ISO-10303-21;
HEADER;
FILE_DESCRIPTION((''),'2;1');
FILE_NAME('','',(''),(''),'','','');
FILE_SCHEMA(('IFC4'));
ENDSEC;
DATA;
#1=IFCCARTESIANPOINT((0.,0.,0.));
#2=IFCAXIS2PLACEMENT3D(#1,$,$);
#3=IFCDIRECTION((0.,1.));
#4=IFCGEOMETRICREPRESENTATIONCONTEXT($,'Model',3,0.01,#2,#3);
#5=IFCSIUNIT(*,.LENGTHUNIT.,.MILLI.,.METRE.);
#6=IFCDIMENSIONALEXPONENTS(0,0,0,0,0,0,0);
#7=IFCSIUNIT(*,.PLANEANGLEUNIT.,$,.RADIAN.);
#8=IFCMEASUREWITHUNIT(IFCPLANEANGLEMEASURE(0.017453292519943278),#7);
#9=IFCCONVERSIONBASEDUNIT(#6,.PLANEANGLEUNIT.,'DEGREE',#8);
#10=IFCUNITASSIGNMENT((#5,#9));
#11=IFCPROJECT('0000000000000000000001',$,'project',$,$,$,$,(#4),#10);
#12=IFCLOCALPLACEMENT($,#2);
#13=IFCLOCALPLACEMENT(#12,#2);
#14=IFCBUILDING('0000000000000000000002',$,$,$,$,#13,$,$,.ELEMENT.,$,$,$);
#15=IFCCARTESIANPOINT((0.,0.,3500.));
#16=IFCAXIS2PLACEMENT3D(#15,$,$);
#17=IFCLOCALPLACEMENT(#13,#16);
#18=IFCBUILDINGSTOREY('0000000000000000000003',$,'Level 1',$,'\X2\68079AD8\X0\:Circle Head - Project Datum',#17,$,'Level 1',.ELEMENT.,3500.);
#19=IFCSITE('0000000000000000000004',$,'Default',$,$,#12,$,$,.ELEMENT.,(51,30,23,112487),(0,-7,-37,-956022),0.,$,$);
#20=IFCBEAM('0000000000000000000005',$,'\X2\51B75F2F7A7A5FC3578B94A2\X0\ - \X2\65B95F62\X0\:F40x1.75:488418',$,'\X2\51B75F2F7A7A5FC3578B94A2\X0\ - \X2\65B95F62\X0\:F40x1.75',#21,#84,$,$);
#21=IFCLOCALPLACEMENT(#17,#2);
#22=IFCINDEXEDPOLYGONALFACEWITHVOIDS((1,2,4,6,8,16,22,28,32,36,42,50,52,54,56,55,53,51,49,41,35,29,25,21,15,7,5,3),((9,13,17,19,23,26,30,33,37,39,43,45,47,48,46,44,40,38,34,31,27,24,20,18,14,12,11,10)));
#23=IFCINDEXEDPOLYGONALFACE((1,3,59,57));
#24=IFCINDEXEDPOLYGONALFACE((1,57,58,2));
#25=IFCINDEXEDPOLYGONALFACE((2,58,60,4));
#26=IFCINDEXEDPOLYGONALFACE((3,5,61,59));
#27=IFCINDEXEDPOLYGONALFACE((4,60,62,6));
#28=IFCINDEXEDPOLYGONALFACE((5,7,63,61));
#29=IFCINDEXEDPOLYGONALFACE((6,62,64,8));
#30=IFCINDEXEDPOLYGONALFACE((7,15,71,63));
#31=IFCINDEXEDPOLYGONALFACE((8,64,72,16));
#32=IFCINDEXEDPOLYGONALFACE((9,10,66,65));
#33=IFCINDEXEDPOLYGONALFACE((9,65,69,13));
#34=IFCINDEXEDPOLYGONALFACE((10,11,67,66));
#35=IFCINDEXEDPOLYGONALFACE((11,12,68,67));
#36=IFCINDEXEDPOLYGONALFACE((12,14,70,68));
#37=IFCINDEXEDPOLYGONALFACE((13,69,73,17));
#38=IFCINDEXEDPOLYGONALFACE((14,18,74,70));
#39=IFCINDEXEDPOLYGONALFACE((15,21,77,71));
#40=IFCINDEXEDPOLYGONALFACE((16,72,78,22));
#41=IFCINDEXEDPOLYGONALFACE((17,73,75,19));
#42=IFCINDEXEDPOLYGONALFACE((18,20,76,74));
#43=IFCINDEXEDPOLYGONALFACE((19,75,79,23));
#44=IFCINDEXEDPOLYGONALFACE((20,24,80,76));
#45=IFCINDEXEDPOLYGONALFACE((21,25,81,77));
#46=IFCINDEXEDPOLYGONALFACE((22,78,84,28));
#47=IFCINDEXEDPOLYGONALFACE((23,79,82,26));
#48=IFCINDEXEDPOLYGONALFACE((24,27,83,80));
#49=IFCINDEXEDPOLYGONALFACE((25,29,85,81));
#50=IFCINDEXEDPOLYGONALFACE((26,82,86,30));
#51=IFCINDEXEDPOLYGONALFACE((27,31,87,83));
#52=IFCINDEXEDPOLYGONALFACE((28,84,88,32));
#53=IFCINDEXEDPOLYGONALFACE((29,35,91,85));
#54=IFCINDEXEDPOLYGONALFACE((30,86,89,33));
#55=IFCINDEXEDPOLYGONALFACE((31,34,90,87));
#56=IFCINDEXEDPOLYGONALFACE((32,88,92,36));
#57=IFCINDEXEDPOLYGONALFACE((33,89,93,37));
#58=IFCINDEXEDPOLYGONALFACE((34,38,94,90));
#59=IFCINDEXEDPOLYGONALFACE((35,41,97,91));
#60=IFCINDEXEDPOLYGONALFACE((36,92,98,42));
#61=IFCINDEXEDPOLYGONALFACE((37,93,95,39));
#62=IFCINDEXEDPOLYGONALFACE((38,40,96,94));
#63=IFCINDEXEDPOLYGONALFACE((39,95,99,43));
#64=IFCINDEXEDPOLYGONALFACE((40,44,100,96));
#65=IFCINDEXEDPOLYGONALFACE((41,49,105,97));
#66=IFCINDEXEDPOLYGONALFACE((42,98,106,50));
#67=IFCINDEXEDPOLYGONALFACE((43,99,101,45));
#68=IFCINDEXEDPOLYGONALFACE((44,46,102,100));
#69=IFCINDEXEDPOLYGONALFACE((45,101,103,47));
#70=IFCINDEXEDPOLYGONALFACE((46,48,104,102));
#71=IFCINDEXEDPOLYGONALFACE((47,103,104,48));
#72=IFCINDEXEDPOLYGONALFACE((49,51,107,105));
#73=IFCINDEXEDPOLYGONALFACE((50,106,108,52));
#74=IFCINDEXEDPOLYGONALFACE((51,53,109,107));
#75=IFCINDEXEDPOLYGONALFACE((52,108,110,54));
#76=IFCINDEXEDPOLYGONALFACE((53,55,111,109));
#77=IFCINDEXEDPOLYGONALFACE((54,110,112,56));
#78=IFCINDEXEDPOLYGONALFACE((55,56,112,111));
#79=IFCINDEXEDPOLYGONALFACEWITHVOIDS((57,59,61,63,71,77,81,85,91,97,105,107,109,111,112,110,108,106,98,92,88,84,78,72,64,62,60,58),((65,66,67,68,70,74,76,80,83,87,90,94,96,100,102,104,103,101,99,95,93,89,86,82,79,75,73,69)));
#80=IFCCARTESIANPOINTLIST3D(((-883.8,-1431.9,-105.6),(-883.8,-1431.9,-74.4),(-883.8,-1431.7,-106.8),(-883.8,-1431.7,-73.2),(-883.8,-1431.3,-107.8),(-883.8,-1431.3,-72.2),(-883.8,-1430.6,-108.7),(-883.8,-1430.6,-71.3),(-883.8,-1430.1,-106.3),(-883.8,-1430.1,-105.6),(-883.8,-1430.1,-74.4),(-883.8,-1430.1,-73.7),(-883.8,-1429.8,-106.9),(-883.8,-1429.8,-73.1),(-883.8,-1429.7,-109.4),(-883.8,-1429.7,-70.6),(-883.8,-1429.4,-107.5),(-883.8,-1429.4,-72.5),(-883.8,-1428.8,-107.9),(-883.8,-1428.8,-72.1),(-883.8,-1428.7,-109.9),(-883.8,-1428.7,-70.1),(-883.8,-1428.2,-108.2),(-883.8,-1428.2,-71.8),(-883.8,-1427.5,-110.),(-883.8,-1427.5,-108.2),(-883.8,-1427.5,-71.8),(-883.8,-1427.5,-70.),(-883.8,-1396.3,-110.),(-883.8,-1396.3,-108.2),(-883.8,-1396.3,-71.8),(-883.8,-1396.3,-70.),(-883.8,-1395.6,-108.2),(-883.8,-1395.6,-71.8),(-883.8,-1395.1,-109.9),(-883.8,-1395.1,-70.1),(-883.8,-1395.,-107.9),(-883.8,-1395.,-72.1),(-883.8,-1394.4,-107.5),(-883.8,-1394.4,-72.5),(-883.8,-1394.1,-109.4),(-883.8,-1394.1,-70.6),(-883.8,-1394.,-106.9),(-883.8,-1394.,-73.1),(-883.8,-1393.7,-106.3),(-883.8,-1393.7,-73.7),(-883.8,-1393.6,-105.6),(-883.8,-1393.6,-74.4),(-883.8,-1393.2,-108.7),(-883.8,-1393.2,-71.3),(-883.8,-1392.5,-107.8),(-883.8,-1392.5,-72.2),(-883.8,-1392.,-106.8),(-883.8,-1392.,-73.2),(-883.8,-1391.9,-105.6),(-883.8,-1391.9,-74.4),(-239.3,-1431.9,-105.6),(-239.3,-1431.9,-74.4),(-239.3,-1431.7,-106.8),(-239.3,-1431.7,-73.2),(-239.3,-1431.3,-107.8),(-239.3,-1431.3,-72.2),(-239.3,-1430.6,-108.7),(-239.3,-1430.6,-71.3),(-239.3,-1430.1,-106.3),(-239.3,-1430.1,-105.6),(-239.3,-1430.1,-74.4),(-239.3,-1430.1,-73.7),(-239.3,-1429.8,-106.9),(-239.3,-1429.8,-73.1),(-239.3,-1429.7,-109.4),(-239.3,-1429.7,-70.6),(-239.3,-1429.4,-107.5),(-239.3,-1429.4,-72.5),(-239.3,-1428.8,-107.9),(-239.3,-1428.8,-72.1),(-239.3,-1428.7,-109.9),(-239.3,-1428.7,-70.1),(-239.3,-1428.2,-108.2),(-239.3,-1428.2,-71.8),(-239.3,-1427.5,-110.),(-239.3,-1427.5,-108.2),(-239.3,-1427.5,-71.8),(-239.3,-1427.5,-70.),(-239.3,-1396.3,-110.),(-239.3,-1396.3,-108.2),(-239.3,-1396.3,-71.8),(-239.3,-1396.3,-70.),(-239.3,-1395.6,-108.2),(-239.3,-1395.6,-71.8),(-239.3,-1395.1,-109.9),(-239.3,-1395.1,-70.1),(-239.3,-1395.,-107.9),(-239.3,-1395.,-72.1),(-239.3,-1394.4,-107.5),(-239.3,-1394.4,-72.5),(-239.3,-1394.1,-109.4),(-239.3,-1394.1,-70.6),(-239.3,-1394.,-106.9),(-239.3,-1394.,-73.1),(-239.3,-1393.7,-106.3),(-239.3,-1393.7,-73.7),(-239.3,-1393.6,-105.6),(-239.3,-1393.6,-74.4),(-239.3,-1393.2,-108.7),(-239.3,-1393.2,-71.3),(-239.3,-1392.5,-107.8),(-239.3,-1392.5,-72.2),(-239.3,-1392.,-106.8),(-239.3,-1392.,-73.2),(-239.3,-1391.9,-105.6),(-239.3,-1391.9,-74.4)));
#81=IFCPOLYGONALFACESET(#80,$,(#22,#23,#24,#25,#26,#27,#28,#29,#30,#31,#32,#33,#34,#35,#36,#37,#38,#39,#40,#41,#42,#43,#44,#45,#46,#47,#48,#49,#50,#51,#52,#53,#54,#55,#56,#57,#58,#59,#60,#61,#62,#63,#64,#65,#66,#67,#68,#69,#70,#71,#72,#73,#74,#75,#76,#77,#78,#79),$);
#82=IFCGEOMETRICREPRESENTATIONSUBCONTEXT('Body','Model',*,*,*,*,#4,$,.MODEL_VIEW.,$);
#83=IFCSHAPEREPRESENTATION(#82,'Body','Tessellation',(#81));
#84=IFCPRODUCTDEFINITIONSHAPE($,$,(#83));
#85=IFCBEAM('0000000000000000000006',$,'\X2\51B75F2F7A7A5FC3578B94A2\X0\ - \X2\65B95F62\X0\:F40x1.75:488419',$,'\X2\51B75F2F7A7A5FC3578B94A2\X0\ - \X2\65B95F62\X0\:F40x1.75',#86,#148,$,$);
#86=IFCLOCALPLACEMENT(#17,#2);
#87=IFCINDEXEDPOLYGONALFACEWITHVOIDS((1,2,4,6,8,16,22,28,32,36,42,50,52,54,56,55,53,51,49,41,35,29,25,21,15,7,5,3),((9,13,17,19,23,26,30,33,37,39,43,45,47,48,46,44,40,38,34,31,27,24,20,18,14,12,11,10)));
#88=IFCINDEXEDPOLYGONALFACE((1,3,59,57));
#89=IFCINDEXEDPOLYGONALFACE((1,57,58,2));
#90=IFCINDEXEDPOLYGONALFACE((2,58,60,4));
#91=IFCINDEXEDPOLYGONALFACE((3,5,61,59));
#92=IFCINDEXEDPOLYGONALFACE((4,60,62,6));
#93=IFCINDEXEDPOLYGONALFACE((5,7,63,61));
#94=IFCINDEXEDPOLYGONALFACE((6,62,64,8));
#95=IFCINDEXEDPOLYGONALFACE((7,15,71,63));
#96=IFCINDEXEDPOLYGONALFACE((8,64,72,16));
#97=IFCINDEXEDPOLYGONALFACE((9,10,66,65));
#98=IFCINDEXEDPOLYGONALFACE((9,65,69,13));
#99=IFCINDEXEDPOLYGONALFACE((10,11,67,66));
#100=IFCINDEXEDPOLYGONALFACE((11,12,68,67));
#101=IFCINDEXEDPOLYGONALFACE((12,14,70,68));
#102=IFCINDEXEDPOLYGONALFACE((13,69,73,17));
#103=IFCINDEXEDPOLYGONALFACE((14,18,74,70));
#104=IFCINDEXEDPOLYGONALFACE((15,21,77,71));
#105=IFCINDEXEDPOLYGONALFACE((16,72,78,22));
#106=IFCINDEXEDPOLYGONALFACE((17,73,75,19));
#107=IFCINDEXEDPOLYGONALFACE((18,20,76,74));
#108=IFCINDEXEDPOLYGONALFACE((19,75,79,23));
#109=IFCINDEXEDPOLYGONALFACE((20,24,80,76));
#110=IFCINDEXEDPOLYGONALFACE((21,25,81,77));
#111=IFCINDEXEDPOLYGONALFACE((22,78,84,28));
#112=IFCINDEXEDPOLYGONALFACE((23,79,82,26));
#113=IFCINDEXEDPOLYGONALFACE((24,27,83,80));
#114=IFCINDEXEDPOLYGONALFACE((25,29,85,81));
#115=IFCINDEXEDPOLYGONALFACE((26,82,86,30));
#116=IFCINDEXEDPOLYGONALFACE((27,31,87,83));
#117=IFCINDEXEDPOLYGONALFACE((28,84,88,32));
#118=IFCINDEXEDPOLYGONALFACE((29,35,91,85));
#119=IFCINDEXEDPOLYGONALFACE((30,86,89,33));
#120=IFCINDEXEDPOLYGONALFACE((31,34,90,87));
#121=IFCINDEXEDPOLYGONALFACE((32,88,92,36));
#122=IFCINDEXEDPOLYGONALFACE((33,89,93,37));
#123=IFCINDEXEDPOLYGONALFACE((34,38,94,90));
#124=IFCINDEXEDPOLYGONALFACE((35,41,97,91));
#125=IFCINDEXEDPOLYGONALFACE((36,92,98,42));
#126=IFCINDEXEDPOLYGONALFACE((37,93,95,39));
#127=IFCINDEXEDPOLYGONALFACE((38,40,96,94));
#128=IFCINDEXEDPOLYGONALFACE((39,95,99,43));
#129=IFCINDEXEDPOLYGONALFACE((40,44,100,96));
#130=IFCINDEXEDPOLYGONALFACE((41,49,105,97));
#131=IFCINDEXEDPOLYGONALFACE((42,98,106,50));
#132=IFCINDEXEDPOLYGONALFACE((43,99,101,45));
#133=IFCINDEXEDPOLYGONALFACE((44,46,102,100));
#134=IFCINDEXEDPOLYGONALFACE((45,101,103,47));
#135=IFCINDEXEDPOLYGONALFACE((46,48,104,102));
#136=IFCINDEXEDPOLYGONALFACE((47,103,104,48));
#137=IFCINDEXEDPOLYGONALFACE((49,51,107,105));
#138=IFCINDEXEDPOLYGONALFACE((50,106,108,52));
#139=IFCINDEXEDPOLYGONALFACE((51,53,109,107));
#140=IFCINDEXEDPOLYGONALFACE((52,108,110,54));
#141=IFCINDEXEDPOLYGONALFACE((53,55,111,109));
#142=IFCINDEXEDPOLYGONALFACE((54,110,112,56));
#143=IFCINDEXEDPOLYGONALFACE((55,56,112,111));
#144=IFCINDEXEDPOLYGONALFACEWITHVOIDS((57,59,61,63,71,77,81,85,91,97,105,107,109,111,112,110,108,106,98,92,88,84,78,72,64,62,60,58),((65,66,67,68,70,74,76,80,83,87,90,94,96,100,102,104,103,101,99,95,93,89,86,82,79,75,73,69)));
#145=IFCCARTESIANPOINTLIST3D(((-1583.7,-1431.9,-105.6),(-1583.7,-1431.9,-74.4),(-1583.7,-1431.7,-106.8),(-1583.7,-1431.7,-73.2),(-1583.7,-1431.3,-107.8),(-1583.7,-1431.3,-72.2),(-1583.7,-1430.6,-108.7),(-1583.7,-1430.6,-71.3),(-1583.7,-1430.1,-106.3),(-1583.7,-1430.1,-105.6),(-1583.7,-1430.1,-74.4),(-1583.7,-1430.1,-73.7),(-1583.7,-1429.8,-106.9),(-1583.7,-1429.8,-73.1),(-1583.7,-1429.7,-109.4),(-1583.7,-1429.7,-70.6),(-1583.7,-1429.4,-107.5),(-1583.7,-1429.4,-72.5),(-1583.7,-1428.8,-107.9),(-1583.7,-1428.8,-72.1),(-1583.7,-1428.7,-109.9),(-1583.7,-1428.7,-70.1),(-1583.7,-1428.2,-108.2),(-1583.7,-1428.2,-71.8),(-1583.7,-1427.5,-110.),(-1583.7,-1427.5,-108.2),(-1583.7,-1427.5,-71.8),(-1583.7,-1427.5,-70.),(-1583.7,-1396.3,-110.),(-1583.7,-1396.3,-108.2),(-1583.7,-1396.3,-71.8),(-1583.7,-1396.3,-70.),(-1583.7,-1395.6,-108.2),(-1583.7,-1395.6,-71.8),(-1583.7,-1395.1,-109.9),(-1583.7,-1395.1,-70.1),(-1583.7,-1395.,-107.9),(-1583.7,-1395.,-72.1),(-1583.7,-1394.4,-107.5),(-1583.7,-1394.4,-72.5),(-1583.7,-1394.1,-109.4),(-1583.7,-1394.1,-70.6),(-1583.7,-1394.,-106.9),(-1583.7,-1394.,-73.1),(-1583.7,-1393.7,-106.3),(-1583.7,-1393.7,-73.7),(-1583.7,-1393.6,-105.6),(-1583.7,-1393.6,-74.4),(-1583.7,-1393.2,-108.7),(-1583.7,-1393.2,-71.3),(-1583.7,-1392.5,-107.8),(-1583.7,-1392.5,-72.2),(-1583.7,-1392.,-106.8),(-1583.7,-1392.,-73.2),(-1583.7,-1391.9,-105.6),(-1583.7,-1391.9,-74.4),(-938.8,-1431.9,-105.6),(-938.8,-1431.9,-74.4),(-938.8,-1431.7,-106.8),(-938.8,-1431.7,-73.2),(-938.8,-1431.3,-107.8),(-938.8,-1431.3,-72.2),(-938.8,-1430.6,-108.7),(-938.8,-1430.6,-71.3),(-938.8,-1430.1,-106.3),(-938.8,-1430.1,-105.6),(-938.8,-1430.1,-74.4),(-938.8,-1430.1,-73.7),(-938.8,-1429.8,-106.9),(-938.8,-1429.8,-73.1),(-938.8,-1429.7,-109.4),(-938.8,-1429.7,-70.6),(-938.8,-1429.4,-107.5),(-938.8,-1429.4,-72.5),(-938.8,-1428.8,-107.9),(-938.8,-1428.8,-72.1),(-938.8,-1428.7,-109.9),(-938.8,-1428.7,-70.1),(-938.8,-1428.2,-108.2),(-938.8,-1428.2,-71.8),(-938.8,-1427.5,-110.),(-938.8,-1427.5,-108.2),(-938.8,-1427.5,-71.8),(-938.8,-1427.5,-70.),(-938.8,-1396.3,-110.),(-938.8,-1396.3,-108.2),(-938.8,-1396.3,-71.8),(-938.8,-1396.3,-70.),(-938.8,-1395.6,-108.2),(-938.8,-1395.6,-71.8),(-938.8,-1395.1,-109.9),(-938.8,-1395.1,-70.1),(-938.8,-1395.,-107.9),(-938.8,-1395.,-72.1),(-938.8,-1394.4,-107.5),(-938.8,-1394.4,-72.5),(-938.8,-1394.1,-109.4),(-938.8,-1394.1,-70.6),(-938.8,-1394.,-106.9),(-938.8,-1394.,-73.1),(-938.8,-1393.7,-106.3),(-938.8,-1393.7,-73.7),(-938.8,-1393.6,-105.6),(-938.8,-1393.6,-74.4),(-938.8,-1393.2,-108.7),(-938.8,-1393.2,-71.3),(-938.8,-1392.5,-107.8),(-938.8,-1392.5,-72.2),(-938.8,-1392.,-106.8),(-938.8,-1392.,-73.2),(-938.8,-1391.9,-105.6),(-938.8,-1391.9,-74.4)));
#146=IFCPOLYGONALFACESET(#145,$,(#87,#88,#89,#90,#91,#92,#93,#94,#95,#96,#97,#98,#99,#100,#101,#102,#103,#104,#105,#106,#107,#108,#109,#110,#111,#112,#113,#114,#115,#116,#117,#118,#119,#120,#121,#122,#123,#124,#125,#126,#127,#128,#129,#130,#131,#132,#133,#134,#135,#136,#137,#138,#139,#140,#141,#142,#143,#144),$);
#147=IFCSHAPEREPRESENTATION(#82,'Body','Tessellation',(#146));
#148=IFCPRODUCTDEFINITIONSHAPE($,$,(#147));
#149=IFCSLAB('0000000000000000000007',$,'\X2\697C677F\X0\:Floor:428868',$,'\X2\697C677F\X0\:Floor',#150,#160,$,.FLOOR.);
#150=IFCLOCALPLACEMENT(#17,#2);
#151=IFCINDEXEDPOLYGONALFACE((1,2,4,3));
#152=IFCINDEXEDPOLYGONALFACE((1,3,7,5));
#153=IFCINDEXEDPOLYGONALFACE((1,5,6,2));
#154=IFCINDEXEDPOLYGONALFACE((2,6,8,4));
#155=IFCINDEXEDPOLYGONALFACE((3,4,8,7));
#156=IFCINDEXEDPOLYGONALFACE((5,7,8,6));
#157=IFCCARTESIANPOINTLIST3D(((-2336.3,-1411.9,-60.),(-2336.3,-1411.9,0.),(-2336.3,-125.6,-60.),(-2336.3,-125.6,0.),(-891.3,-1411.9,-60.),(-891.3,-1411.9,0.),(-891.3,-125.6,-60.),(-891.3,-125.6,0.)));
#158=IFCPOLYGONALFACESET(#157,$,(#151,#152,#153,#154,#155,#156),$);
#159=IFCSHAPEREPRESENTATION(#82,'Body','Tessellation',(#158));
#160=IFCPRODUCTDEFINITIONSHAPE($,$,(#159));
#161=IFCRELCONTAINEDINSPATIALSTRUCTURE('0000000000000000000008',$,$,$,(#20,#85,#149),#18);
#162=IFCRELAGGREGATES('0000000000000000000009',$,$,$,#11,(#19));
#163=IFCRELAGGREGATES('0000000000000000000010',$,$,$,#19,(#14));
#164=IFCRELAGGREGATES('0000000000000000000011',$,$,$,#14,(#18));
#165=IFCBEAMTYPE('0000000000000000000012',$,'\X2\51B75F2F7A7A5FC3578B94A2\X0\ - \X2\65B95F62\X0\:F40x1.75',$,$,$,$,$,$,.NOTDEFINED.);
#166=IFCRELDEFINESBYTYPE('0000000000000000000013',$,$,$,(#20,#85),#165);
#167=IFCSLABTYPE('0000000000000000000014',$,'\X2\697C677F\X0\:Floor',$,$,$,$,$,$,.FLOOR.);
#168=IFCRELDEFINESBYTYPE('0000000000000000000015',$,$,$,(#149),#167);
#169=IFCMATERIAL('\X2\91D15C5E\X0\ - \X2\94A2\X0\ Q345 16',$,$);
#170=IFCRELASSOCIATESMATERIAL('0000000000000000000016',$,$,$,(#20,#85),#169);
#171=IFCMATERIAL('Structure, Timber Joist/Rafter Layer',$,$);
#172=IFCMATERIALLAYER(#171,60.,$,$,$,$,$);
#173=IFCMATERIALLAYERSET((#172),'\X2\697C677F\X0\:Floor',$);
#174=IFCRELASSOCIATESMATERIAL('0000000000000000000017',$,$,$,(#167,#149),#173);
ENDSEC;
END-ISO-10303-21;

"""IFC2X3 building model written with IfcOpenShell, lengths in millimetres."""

from ifc_helpers import new_model, entity, si_unit, converted_unit, direction, frame, frame_2d, origin, place, context, subcontext, project, spatial, polyline, circle_curve, parameter, trimmed, segment, composite_curve, rectangle, outline, extrude, material, layer, layer_set, layer_usage, type_object, element, save


model = new_model("IFC2X3")

# Units and contexts
model_context = context("Model", 3, precision=0.01, world=origin(), true_north=direction((0.0, 1.0)))
body_context = subcontext(model_context, "Body", "Model", "MODEL_VIEW")
ifc_project = project(units=[si_unit("LENGTHUNIT", "METRE", prefix="MILLI"), converted_unit("PLANEANGLEUNIT", "DEGREE", entity("IfcPlaneAngleMeasure", 0.017453292519943278), si_unit("PLANEANGLEUNIT", "RADIAN"), dimensions=[0, 0, 0, 0, 0, 0, 0])], contexts=[model_context])

# Site, building, storey
site_placement = place(None, origin())
site = spatial("IfcSite", under=ifc_project, at=site_placement, Name="Default", CompositionType="ELEMENT", RefLatitude=(51, 30, 23, 112487), RefLongitude=(0, -7, -37, -956022), RefElevation=0.0)
building_placement = place(site_placement, origin())
building = spatial("IfcBuilding", under=site, at=building_placement, CompositionType="ELEMENT")
storey_placement = place(building_placement, frame((0.0, 0.0, 3500.0)))
storey = spatial("IfcBuildingStorey", under=building, at=storey_placement, Name="Level 1", ObjectType="标高:Circle Head - Project Datum", LongName="Level 1", CompositionType="ELEMENT", Elevation=3500.0)

# Beams
ifc_material_1 = material(Name="金属 - 钢 Q345 16")
beam_type_1 = type_object("IfcBeamType", Name="冷弯空心型钢 - 方形:F40x1.75", PredefinedType="NOTDEFINED")
beam_1_placement = place(storey_placement, frame((-911.3, -1411.9, -70.0)))
element("IfcBeam", 1, at=beam_1_placement, inside=storey, type_object=beam_type_1, material=ifc_material_1, Name="冷弯空心型钢 - 方形:F40x1.75:488418", ObjectType="冷弯空心型钢 - 方形:F40x1.75", context=body_context, shape_type="SweptSolid", body=[
    extrude(outline(composite_curve([segment(trimmed(circle_curve(frame_2d((-15.6, 15.6), x_axis=(1.0, 0.0)), 4.4), [parameter(90.0)], [parameter(180.0)], True, "PARAMETER"), True, "CONTINUOUS"), segment(polyline([(-20.0, 15.6), (-20.0, -15.6)]), True, "CONTINUOUS"), segment(trimmed(circle_curve(frame_2d((-15.6, -15.6), x_axis=(1.0, 0.0)), 4.4), [parameter(180.0)], [parameter(270.0)], True, "PARAMETER"), True, "CONTINUOUS"), segment(polyline([(-15.6, -20.0), (15.6, -20.0)]), True, "CONTINUOUS"), segment(trimmed(circle_curve(frame_2d((15.6, -15.6), x_axis=(1.0, 0.0)), 4.4), [parameter(270.0)], [parameter(0.0)], True, "PARAMETER"), True, "CONTINUOUS"), segment(polyline([(20.0, -15.6), (20.0, 15.6)]), True, "CONTINUOUS"), segment(trimmed(circle_curve(frame_2d((15.6, 15.6), x_axis=(1.0, 0.0)), 4.4), [parameter(0.0)], [parameter(90.0)], True, "PARAMETER"), True, "CONTINUOUS"), segment(polyline([(15.6, 20.0), (-15.6, 20.0)]), True, "CONTINUOUS")], self_intersect=False), holes=[composite_curve([segment(polyline([(-15.6, 18.3), (15.6, 18.3)]), True, "CONTINUOUS"), segment(trimmed(circle_curve(frame_2d((15.6, 15.6), x_axis=(1.0, 0.0)), 2.6), [parameter(0.0)], [parameter(90.0)], True, "PARAMETER"), False, "CONTINUOUS"), segment(polyline([(18.2, 15.6), (18.2, -15.6)]), True, "CONTINUOUS"), segment(trimmed(circle_curve(frame_2d((15.6, -15.6), x_axis=(1.0, 0.0)), 2.6), [parameter(270.0)], [parameter(360.0)], True, "PARAMETER"), False, "CONTINUOUS"), segment(polyline([(15.6, -18.3), (-15.6, -18.3)]), True, "CONTINUOUS"), segment(trimmed(circle_curve(frame_2d((-15.6, -15.6), x_axis=(1.0, 0.0)), 2.6), [parameter(180.0)], [parameter(270.0)], True, "PARAMETER"), False, "CONTINUOUS"), segment(polyline([(-18.3, -15.6), (-18.3, 15.6)]), True, "CONTINUOUS"), segment(trimmed(circle_curve(frame_2d((-15.6, 15.6), x_axis=(1.0, 0.0)), 2.6), [parameter(90.0)], [parameter(180.0)], True, "PARAMETER"), False, "CONTINUOUS")], self_intersect=False)]), frame((27.5, 0.0, -20.0), z_axis=(1.0, 0.0, 0.0), x_axis=(0.0, 1.0, 0.0)), (0.0, 0.0, 1.0), 644.5),
])
beam_2_placement = place(storey_placement, frame((-1651.3, -1411.9, -70.0)))
element("IfcBeam", 2, at=beam_2_placement, inside=storey, type_object=beam_type_1, material=ifc_material_1, Name="冷弯空心型钢 - 方形:F40x1.75:488419", ObjectType="冷弯空心型钢 - 方形:F40x1.75", context=body_context, shape_type="SweptSolid", body=[
    extrude(outline(composite_curve([segment(trimmed(circle_curve(frame_2d((-15.6, 15.6), x_axis=(1.0, 0.0)), 4.4), [parameter(90.0)], [parameter(180.0)], True, "PARAMETER"), True, "CONTINUOUS"), segment(polyline([(-20.0, 15.6), (-20.0, -15.6)]), True, "CONTINUOUS"), segment(trimmed(circle_curve(frame_2d((-15.6, -15.6), x_axis=(1.0, 0.0)), 4.4), [parameter(180.0)], [parameter(270.0)], True, "PARAMETER"), True, "CONTINUOUS"), segment(polyline([(-15.6, -20.0), (15.6, -20.0)]), True, "CONTINUOUS"), segment(trimmed(circle_curve(frame_2d((15.6, -15.6), x_axis=(1.0, 0.0)), 4.4), [parameter(270.0)], [parameter(0.0)], True, "PARAMETER"), True, "CONTINUOUS"), segment(polyline([(20.0, -15.6), (20.0, 15.6)]), True, "CONTINUOUS"), segment(trimmed(circle_curve(frame_2d((15.6, 15.6), x_axis=(1.0, 0.0)), 4.4), [parameter(0.0)], [parameter(90.0)], True, "PARAMETER"), True, "CONTINUOUS"), segment(polyline([(15.6, 20.0), (-15.6, 20.0)]), True, "CONTINUOUS")], self_intersect=False), holes=[composite_curve([segment(polyline([(-15.6, 18.3), (15.6, 18.3)]), True, "CONTINUOUS"), segment(trimmed(circle_curve(frame_2d((15.6, 15.6), x_axis=(1.0, 0.0)), 2.6), [parameter(0.0)], [parameter(90.0)], True, "PARAMETER"), False, "CONTINUOUS"), segment(polyline([(18.2, 15.6), (18.2, -15.6)]), True, "CONTINUOUS"), segment(trimmed(circle_curve(frame_2d((15.6, -15.6), x_axis=(1.0, 0.0)), 2.6), [parameter(270.0)], [parameter(360.0)], True, "PARAMETER"), False, "CONTINUOUS"), segment(polyline([(15.6, -18.3), (-15.6, -18.3)]), True, "CONTINUOUS"), segment(trimmed(circle_curve(frame_2d((-15.6, -15.6), x_axis=(1.0, 0.0)), 2.6), [parameter(180.0)], [parameter(270.0)], True, "PARAMETER"), False, "CONTINUOUS"), segment(polyline([(-18.3, -15.6), (-18.3, 15.6)]), True, "CONTINUOUS"), segment(trimmed(circle_curve(frame_2d((-15.6, 15.6), x_axis=(1.0, 0.0)), 2.6), [parameter(90.0)], [parameter(180.0)], True, "PARAMETER"), False, "CONTINUOUS")], self_intersect=False)]), frame((67.6, 0.0, -20.0), z_axis=(1.0, 0.0, 0.0), x_axis=(0.0, 1.0, 0.0)), (0.0, 0.0, 1.0), 644.9),
])

# Slab
ifc_material_2 = material(Name="Structure, Timber Joist/Rafter Layer")
ifc_layer = layer(ifc_material_2, 60.0)
ifc_layer_set = layer_set([ifc_layer], Name="楼板:Floor")
slab_type = type_object("IfcSlabType", Name="楼板:Floor", PredefinedType="FLOOR", material=ifc_layer_set)
ifc_layer_usage_1 = layer_usage(ifc_layer_set, "AXIS3", "POSITIVE", 0.0)
slab_1_placement = place(storey_placement, origin())
element("IfcSlab", 3, at=slab_1_placement, inside=storey, type_object=slab_type, material=ifc_layer_usage_1, Name="楼板:Floor:428868", ObjectType="楼板:Floor", PredefinedType="FLOOR", context=body_context, shape_type="SweptSolid", body=[
    extrude(rectangle(XDim=1286.3, YDim=1445.0, at=frame_2d((0.0, 0.0), x_axis=(1.0, 0.0))), frame((-1613.8, -768.8, 0.0), z_axis=(0.0, 0.0, -1.0), x_axis=(0.0, 1.0, 0.0)), (0.0, 0.0, 1.0), 60.0),
])

save(model, "model.ifc")
